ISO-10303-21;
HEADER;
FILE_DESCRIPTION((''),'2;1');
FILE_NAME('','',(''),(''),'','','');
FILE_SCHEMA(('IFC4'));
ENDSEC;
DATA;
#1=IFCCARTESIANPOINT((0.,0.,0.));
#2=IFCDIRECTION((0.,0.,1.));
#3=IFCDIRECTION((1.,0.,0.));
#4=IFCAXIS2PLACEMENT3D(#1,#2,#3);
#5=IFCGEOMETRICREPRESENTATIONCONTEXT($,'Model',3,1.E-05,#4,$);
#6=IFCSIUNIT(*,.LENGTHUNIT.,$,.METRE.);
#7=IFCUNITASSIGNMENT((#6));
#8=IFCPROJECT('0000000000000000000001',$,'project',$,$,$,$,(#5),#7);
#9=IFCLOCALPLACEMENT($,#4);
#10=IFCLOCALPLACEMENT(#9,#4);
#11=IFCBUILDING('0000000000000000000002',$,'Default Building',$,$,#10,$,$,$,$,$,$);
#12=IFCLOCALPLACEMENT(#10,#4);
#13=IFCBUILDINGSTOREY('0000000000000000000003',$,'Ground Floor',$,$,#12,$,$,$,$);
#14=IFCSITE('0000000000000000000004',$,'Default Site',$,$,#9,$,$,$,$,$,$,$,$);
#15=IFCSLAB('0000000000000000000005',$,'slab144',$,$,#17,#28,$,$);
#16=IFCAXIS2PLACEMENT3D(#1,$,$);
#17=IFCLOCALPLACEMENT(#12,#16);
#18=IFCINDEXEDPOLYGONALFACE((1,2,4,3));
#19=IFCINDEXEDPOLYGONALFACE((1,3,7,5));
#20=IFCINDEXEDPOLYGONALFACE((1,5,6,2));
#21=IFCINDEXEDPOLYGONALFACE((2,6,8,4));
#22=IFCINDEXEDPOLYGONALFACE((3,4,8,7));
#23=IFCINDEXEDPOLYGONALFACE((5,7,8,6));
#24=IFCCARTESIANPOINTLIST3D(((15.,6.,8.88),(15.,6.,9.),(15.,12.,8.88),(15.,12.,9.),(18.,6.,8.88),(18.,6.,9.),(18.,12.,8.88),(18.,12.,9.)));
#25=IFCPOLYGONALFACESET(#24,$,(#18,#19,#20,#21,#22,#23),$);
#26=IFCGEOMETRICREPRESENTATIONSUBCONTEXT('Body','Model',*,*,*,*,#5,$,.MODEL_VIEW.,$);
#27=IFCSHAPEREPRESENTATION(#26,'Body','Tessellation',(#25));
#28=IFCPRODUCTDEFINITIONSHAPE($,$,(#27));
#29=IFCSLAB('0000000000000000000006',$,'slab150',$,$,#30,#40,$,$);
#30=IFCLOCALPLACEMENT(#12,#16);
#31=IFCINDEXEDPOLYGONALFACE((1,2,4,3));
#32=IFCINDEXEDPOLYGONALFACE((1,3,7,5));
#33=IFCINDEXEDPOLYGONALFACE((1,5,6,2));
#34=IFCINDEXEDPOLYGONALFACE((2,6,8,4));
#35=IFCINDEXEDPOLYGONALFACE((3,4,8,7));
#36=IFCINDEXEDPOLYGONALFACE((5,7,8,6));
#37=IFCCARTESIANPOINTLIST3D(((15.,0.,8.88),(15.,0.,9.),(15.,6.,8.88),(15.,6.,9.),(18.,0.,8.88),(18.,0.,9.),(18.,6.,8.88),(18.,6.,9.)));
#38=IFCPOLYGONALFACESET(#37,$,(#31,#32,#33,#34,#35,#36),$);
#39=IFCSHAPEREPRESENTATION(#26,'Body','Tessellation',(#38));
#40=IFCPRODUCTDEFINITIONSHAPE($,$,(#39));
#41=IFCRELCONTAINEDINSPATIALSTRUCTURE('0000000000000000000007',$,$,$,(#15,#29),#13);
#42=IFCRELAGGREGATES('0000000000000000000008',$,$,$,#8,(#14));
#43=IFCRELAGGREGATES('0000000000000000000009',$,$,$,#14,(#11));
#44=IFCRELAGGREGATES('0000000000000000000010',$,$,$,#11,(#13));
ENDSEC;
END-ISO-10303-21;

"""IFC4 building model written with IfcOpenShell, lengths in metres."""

from ifc_helpers import new_model, si_unit, frame, origin_with_axes, place, context, subcontext, project, spatial, indexed_curve, outline, extrude, element, save


model = new_model("IFC4")

# Units and contexts
model_context = context("Model", 3, precision=1e-05, world=origin_with_axes())
body_context = subcontext(model_context, "Body", "Model", "MODEL_VIEW")
ifc_project = project(units=[si_unit("LENGTHUNIT", "METRE")], contexts=[model_context])

# Site, building, storey
site_placement = place(None, origin_with_axes())
site = spatial("IfcSite", under=ifc_project, at=site_placement, Name="Default Site")
building_placement = place(site_placement, origin_with_axes())
building = spatial("IfcBuilding", under=site, at=building_placement, Name="Default Building")
storey_placement = place(building_placement, origin_with_axes())
storey = spatial("IfcBuildingStorey", under=building, at=storey_placement, Name="Ground Floor")

# Slabs
for number, where, z_axis, x_axis, name in (
    (1, (15.0, 6.0, 8.88), (0.0, 0.0, 1.0), (1.0, 0.0, 0.0), "slab144"),
    (2, (15.0, 0.0, 8.88), (0.0, 0.0, 1.0), (1.0, 0.0, 0.0), "slab150"),
):
    element("IfcSlab", number, at=place(storey_placement, frame(where, z_axis=z_axis, x_axis=x_axis)), inside=storey, Name=name, context=body_context, shape_type="SweptSolid", body=[
        extrude(outline(indexed_curve([(0.0, 0.0), (0.0, 6.0), (3.0, 6.0), (3.0, 0.0), (0.0, 0.0)], self_intersect=False)), origin_with_axes(), (0.0, 0.0, 1.0), 0.12),
    ])

save(model, "model.ifc")
